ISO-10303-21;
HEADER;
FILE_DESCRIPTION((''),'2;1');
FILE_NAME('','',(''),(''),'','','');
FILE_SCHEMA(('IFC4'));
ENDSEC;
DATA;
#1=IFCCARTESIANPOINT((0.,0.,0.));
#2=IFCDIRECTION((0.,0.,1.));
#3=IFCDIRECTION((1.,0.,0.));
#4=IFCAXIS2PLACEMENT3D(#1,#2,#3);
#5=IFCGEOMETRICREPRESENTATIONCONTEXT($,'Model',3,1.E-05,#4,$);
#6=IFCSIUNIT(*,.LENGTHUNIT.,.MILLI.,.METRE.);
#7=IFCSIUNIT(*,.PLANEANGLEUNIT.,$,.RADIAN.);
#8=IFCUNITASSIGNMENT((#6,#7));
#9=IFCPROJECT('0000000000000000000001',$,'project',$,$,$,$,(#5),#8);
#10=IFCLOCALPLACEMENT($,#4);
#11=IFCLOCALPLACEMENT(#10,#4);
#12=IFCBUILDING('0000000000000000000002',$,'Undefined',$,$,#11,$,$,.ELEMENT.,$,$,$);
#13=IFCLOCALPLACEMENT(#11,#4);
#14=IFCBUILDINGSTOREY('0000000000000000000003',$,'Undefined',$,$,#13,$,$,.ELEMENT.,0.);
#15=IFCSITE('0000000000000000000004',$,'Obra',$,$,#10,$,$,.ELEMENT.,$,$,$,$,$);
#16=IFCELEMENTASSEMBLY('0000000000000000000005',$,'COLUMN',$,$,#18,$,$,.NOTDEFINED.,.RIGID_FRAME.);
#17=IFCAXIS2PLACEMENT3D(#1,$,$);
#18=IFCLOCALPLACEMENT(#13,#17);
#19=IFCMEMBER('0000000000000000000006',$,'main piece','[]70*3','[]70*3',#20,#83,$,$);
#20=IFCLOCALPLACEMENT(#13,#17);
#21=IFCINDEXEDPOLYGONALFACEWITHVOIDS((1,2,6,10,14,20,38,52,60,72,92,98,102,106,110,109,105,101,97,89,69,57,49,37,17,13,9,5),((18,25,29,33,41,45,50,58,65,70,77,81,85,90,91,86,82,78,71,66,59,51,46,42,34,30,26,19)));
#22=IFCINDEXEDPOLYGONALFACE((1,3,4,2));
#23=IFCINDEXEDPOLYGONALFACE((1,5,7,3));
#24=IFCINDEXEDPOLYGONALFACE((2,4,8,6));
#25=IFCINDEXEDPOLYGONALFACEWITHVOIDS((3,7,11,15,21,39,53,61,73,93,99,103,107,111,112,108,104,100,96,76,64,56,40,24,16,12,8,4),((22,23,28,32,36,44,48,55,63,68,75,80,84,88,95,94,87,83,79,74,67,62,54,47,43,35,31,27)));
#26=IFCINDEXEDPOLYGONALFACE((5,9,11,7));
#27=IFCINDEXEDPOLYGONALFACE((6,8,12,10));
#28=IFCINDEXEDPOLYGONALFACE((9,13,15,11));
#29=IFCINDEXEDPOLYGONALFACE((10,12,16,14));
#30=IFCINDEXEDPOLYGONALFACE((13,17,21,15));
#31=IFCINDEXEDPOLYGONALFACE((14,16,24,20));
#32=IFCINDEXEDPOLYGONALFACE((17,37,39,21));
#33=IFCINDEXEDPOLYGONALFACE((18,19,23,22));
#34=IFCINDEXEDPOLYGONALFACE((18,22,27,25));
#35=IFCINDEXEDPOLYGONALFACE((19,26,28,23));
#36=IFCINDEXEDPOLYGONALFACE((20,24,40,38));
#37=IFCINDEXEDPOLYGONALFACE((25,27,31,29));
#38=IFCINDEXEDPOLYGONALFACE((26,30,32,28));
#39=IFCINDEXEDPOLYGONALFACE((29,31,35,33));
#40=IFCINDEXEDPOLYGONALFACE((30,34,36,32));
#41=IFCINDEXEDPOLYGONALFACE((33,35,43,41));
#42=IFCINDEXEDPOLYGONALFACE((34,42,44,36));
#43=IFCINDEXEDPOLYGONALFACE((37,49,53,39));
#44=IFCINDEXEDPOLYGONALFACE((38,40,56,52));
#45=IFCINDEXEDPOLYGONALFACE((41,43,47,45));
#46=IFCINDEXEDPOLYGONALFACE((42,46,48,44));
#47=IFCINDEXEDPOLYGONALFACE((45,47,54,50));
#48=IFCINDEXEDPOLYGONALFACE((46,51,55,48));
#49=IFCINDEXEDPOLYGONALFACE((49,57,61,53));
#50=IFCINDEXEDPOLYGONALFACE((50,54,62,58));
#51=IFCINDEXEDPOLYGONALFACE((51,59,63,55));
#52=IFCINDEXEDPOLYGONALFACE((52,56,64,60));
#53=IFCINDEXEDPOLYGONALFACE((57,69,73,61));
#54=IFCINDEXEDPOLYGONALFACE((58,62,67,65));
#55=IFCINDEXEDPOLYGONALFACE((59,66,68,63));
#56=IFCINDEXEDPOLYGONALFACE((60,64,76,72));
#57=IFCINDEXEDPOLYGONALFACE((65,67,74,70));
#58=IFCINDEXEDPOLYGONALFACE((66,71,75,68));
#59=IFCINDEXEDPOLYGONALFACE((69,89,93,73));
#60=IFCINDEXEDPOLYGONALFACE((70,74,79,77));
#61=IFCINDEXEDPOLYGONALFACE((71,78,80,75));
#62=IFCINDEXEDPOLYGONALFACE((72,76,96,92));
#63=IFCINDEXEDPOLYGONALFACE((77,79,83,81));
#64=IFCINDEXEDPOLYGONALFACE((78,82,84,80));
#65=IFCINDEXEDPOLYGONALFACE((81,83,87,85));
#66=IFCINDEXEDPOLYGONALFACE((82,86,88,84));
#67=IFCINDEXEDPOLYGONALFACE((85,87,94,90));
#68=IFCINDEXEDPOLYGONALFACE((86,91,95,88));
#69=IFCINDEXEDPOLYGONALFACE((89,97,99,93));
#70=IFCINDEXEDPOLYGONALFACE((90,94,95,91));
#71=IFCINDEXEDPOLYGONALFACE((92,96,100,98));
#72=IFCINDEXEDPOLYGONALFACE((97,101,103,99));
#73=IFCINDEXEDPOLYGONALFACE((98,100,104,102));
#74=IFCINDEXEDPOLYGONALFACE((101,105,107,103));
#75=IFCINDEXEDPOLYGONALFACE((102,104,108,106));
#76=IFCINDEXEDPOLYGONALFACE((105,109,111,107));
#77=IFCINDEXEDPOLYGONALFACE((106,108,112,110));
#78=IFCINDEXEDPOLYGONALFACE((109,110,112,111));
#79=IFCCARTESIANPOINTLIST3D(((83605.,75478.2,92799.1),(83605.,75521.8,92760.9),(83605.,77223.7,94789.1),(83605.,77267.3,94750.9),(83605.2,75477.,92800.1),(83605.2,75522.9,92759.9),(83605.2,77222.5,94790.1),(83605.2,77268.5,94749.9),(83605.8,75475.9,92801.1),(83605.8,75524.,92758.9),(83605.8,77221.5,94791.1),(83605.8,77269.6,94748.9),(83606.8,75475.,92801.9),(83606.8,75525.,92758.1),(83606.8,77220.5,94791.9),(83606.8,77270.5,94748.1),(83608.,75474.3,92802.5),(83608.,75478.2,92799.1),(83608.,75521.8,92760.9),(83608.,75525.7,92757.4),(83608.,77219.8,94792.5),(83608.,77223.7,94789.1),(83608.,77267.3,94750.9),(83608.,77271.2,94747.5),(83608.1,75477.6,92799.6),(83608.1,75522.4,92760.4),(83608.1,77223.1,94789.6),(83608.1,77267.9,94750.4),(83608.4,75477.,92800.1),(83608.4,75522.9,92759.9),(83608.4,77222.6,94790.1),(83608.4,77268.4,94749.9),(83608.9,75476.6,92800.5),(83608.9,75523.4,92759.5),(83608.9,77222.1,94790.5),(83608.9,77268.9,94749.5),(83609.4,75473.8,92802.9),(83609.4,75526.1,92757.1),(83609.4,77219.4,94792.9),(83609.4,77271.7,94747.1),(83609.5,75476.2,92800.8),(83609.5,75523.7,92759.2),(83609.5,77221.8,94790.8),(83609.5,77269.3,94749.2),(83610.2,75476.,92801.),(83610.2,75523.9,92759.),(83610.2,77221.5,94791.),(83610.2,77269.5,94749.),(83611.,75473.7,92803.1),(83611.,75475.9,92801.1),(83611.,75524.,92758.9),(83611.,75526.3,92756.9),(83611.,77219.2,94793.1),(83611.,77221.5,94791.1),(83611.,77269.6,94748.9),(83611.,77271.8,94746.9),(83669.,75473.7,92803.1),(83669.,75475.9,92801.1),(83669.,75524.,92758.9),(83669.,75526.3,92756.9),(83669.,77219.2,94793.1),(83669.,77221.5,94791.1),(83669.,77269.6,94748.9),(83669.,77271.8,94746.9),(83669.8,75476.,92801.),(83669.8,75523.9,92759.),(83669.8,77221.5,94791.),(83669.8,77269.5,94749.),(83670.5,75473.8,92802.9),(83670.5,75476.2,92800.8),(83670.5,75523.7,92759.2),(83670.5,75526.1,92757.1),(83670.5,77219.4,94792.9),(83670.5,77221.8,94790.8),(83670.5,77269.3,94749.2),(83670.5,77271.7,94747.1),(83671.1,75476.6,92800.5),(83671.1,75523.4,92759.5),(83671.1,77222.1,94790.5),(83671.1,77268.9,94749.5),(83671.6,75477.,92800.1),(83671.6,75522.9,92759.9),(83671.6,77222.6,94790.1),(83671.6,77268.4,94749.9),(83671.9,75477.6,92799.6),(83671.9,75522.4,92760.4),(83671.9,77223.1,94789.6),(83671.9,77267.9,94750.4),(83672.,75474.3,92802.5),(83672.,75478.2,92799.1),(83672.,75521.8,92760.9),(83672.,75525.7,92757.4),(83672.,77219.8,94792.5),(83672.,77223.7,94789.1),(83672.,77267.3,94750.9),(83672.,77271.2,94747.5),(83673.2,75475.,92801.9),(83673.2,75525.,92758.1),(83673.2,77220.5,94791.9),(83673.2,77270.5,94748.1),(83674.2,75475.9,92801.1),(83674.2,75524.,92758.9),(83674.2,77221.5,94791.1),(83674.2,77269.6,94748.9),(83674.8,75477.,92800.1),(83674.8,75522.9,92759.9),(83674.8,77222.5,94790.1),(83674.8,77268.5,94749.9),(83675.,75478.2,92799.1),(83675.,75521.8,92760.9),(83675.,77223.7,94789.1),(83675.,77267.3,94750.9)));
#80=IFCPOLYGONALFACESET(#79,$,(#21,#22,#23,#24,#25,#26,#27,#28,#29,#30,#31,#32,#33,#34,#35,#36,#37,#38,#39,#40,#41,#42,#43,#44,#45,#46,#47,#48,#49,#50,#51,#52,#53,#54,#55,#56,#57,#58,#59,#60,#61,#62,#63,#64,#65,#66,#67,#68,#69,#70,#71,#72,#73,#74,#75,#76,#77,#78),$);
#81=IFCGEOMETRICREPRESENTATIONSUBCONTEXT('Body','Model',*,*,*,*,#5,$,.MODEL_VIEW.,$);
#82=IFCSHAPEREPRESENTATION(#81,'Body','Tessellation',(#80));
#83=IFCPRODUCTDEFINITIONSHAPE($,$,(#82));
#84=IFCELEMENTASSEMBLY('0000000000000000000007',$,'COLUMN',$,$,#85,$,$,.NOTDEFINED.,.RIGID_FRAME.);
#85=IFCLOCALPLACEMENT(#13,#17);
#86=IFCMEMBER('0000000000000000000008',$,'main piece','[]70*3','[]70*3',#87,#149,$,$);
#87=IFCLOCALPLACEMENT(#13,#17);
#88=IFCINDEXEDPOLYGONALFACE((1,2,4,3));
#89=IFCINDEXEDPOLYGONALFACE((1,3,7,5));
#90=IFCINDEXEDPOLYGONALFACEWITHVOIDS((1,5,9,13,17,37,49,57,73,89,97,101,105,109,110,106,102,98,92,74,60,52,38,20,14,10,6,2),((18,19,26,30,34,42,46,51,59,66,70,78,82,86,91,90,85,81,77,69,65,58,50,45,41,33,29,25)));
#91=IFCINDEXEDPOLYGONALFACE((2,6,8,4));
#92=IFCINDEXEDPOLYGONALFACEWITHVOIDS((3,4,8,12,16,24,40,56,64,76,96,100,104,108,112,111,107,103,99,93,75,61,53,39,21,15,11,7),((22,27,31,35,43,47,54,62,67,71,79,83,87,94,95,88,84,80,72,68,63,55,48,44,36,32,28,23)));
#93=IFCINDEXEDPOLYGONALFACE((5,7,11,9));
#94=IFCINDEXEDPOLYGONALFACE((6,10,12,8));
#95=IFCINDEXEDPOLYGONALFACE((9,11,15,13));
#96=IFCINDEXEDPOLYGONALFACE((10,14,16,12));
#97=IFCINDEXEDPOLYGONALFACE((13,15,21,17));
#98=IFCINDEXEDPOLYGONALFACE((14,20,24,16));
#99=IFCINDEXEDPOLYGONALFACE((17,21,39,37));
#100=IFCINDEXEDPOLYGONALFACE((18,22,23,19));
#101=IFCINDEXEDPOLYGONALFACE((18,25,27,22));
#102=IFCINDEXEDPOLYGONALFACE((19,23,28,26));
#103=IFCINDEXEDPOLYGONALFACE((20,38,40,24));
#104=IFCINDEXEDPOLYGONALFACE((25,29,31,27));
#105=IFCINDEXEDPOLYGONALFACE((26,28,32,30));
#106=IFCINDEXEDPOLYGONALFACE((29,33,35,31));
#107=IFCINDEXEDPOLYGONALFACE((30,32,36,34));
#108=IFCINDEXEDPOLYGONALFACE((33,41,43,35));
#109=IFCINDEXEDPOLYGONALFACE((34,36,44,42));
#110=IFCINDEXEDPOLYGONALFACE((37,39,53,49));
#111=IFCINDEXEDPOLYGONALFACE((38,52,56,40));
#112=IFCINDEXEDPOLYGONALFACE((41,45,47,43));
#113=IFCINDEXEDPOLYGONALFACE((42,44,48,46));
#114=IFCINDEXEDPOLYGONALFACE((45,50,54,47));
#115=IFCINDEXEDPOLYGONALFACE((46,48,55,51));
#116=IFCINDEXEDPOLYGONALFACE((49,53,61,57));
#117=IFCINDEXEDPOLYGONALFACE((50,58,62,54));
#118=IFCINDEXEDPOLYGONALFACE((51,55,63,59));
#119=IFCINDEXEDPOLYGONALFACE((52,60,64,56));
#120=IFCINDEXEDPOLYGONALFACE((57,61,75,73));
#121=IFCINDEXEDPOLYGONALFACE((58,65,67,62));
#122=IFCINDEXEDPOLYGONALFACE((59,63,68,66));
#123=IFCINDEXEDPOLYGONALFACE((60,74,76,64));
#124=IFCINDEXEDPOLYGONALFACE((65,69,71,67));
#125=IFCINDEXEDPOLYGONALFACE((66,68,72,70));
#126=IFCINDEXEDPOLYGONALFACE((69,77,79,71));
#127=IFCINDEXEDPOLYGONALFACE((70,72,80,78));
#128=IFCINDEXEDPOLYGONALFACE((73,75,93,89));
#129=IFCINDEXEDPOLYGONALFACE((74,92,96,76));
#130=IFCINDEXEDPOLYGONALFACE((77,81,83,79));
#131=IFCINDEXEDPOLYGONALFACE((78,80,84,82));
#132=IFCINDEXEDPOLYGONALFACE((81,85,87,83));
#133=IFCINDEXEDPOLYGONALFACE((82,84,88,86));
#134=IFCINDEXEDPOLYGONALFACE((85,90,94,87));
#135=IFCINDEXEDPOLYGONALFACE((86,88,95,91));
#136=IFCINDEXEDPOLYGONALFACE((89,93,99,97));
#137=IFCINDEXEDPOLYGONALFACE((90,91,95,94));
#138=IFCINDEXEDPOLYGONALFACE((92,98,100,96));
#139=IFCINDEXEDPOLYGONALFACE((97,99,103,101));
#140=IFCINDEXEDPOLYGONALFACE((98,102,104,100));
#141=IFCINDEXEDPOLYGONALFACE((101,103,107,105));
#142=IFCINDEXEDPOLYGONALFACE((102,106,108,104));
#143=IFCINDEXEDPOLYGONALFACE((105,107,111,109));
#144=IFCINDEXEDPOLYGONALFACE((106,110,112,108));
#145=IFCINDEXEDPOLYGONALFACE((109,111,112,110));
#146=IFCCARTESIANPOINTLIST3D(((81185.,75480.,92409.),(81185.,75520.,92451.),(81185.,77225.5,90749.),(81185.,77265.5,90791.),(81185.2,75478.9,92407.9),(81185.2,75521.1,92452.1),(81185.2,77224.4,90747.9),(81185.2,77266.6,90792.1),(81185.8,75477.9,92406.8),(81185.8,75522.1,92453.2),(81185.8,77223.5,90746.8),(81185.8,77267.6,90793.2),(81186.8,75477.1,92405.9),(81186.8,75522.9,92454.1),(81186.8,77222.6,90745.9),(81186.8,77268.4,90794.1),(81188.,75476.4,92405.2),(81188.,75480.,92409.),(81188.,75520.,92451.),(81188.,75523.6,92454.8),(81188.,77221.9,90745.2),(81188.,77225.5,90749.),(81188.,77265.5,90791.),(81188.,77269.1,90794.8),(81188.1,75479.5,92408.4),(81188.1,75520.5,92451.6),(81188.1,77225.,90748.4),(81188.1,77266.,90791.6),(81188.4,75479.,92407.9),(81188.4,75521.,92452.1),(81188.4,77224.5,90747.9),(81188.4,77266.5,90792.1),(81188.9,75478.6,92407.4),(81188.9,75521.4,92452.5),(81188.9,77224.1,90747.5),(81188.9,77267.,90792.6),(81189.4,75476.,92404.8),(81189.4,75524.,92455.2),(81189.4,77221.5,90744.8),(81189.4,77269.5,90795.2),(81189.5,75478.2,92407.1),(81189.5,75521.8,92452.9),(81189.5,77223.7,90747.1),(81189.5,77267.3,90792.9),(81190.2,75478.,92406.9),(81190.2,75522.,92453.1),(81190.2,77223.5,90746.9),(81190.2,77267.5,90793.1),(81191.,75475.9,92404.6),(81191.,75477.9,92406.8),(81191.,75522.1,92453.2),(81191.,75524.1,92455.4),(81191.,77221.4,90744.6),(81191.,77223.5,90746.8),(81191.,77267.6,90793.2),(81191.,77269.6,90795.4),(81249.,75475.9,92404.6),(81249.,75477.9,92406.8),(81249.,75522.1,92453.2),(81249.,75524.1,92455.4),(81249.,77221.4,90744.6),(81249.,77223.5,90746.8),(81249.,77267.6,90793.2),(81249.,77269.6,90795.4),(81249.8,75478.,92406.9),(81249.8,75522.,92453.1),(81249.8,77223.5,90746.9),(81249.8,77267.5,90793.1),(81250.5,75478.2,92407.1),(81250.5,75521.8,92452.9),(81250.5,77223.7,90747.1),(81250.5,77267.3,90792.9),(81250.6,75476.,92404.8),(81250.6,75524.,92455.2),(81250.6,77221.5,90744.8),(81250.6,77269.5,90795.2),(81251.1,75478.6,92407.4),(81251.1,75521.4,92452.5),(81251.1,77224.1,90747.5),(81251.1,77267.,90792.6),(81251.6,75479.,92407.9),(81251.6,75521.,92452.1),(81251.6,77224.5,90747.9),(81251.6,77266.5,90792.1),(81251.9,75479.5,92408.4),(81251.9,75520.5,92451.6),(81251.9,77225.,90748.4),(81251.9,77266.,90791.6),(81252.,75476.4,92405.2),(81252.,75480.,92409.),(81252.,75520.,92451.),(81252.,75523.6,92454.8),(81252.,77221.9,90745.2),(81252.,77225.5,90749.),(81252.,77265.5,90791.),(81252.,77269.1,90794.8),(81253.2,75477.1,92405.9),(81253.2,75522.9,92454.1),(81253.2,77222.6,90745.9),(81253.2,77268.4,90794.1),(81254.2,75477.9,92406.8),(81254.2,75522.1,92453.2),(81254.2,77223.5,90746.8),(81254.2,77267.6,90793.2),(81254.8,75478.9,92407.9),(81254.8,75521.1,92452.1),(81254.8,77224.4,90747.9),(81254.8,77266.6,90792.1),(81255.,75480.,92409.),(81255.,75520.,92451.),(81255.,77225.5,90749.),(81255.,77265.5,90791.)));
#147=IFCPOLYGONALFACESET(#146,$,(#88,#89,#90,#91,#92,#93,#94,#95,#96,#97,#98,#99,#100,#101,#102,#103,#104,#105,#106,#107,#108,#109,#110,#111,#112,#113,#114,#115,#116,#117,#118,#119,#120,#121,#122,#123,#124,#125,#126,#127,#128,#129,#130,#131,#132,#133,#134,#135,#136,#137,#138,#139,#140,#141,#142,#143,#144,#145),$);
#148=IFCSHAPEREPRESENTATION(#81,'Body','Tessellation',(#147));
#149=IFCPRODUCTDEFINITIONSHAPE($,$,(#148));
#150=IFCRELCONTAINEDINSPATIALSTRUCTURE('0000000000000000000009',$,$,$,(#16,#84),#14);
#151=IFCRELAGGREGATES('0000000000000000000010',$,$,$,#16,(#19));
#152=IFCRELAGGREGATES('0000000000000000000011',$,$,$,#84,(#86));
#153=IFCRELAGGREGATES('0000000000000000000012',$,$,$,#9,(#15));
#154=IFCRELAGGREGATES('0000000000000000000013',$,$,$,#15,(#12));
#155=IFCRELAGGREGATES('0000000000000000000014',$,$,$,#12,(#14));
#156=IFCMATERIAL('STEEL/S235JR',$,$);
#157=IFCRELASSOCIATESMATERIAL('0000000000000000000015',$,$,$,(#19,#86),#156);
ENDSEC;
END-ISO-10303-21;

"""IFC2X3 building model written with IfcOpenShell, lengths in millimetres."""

from ifc_helpers import new_model, si_unit, frame, origin_with_axes, origin_2d_with_axis, place, context, subcontext, project, spatial, hollow_rectangle, extrude, material, element, aggregate, save


model = new_model("IFC2X3")

# Units and contexts
model_context = context("Model", 3, precision=1e-05, world=origin_with_axes())
body_context = subcontext(model_context, "Body", "Model", "MODEL_VIEW")
ifc_project = project(units=[si_unit("LENGTHUNIT", "METRE", prefix="MILLI"), si_unit("PLANEANGLEUNIT", "RADIAN")], contexts=[model_context])

# Site, building, storey
site_placement = place(None, origin_with_axes())
site = spatial("IfcSite", under=ifc_project, at=site_placement, Name="Obra", CompositionType="ELEMENT")
building_placement = place(site_placement, origin_with_axes())
building = spatial("IfcBuilding", under=site, at=building_placement, Name="Undefined", CompositionType="ELEMENT")
storey_placement = place(building_placement, origin_with_axes())
storey = spatial("IfcBuildingStorey", under=building, at=storey_placement, Name="Undefined", CompositionType="ELEMENT", Elevation=0.0)

# Shared definitions
ifc_material = material(Name="STEEL/S235JR")

# Element assemblies, members
assembly_1_placement = place(storey_placement, origin_with_axes())
assembly_1 = element("IfcElementAssembly", 1, at=assembly_1_placement, inside=storey, Name="COLUMN", AssemblyPlace="NOTDEFINED", PredefinedType="RIGID_FRAME")
member_1_placement = place(assembly_1_placement, frame((83640.0, 75500.0, 92780.0), z_axis=(-1.0, 0.0, 0.0), x_axis=(0.0, 0.659423, 0.751772)))
member_1 = element("IfcMember", 2, at=member_1_placement, material=ifc_material, Name="main piece", Description="[]70*3", ObjectType="[]70*3", context=body_context, shape_type="SweptSolid", body=[
    extrude(hollow_rectangle(XDim=70.0, YDim=70.0, WallThickness=3.0, InnerFilletRadius=3.0, OuterFilletRadius=6.0, at=origin_2d_with_axis()), frame((2647.1, 0.0, 0.0), z_axis=(-1.0, 0.0, 0.0), x_axis=(0.0, -1.0, 0.0)), (0.0, 0.0, 1.0), 2647.1),
])
aggregate(assembly_1, [member_1])
assembly_2_placement = place(storey_placement, origin_with_axes())
assembly_2 = element("IfcElementAssembly", 3, at=assembly_2_placement, inside=storey, Name="COLUMN", AssemblyPlace="NOTDEFINED", PredefinedType="RIGID_FRAME")
member_2_placement = place(assembly_2_placement, frame((81220.0, 77245.5, 90770.0), z_axis=(1.0, 0.0, 0.0), x_axis=(0.0, -0.724633, 0.689135)))
member_2 = element("IfcMember", 4, at=member_2_placement, material=ifc_material, Name="main piece", Description="[]70*3", ObjectType="[]70*3", context=body_context, shape_type="SweptSolid", body=[
    extrude(hollow_rectangle(XDim=70.0, YDim=70.0, WallThickness=3.0, InnerFilletRadius=3.0, OuterFilletRadius=6.0, at=origin_2d_with_axis()), frame((2408.8, 0.0, 0.0), z_axis=(-1.0, 0.0, 0.0), x_axis=(0.0, -1.0, 0.0)), (0.0, 0.0, 1.0), 2408.8),
])
aggregate(assembly_2, [member_2])

save(model, "model.ifc")
